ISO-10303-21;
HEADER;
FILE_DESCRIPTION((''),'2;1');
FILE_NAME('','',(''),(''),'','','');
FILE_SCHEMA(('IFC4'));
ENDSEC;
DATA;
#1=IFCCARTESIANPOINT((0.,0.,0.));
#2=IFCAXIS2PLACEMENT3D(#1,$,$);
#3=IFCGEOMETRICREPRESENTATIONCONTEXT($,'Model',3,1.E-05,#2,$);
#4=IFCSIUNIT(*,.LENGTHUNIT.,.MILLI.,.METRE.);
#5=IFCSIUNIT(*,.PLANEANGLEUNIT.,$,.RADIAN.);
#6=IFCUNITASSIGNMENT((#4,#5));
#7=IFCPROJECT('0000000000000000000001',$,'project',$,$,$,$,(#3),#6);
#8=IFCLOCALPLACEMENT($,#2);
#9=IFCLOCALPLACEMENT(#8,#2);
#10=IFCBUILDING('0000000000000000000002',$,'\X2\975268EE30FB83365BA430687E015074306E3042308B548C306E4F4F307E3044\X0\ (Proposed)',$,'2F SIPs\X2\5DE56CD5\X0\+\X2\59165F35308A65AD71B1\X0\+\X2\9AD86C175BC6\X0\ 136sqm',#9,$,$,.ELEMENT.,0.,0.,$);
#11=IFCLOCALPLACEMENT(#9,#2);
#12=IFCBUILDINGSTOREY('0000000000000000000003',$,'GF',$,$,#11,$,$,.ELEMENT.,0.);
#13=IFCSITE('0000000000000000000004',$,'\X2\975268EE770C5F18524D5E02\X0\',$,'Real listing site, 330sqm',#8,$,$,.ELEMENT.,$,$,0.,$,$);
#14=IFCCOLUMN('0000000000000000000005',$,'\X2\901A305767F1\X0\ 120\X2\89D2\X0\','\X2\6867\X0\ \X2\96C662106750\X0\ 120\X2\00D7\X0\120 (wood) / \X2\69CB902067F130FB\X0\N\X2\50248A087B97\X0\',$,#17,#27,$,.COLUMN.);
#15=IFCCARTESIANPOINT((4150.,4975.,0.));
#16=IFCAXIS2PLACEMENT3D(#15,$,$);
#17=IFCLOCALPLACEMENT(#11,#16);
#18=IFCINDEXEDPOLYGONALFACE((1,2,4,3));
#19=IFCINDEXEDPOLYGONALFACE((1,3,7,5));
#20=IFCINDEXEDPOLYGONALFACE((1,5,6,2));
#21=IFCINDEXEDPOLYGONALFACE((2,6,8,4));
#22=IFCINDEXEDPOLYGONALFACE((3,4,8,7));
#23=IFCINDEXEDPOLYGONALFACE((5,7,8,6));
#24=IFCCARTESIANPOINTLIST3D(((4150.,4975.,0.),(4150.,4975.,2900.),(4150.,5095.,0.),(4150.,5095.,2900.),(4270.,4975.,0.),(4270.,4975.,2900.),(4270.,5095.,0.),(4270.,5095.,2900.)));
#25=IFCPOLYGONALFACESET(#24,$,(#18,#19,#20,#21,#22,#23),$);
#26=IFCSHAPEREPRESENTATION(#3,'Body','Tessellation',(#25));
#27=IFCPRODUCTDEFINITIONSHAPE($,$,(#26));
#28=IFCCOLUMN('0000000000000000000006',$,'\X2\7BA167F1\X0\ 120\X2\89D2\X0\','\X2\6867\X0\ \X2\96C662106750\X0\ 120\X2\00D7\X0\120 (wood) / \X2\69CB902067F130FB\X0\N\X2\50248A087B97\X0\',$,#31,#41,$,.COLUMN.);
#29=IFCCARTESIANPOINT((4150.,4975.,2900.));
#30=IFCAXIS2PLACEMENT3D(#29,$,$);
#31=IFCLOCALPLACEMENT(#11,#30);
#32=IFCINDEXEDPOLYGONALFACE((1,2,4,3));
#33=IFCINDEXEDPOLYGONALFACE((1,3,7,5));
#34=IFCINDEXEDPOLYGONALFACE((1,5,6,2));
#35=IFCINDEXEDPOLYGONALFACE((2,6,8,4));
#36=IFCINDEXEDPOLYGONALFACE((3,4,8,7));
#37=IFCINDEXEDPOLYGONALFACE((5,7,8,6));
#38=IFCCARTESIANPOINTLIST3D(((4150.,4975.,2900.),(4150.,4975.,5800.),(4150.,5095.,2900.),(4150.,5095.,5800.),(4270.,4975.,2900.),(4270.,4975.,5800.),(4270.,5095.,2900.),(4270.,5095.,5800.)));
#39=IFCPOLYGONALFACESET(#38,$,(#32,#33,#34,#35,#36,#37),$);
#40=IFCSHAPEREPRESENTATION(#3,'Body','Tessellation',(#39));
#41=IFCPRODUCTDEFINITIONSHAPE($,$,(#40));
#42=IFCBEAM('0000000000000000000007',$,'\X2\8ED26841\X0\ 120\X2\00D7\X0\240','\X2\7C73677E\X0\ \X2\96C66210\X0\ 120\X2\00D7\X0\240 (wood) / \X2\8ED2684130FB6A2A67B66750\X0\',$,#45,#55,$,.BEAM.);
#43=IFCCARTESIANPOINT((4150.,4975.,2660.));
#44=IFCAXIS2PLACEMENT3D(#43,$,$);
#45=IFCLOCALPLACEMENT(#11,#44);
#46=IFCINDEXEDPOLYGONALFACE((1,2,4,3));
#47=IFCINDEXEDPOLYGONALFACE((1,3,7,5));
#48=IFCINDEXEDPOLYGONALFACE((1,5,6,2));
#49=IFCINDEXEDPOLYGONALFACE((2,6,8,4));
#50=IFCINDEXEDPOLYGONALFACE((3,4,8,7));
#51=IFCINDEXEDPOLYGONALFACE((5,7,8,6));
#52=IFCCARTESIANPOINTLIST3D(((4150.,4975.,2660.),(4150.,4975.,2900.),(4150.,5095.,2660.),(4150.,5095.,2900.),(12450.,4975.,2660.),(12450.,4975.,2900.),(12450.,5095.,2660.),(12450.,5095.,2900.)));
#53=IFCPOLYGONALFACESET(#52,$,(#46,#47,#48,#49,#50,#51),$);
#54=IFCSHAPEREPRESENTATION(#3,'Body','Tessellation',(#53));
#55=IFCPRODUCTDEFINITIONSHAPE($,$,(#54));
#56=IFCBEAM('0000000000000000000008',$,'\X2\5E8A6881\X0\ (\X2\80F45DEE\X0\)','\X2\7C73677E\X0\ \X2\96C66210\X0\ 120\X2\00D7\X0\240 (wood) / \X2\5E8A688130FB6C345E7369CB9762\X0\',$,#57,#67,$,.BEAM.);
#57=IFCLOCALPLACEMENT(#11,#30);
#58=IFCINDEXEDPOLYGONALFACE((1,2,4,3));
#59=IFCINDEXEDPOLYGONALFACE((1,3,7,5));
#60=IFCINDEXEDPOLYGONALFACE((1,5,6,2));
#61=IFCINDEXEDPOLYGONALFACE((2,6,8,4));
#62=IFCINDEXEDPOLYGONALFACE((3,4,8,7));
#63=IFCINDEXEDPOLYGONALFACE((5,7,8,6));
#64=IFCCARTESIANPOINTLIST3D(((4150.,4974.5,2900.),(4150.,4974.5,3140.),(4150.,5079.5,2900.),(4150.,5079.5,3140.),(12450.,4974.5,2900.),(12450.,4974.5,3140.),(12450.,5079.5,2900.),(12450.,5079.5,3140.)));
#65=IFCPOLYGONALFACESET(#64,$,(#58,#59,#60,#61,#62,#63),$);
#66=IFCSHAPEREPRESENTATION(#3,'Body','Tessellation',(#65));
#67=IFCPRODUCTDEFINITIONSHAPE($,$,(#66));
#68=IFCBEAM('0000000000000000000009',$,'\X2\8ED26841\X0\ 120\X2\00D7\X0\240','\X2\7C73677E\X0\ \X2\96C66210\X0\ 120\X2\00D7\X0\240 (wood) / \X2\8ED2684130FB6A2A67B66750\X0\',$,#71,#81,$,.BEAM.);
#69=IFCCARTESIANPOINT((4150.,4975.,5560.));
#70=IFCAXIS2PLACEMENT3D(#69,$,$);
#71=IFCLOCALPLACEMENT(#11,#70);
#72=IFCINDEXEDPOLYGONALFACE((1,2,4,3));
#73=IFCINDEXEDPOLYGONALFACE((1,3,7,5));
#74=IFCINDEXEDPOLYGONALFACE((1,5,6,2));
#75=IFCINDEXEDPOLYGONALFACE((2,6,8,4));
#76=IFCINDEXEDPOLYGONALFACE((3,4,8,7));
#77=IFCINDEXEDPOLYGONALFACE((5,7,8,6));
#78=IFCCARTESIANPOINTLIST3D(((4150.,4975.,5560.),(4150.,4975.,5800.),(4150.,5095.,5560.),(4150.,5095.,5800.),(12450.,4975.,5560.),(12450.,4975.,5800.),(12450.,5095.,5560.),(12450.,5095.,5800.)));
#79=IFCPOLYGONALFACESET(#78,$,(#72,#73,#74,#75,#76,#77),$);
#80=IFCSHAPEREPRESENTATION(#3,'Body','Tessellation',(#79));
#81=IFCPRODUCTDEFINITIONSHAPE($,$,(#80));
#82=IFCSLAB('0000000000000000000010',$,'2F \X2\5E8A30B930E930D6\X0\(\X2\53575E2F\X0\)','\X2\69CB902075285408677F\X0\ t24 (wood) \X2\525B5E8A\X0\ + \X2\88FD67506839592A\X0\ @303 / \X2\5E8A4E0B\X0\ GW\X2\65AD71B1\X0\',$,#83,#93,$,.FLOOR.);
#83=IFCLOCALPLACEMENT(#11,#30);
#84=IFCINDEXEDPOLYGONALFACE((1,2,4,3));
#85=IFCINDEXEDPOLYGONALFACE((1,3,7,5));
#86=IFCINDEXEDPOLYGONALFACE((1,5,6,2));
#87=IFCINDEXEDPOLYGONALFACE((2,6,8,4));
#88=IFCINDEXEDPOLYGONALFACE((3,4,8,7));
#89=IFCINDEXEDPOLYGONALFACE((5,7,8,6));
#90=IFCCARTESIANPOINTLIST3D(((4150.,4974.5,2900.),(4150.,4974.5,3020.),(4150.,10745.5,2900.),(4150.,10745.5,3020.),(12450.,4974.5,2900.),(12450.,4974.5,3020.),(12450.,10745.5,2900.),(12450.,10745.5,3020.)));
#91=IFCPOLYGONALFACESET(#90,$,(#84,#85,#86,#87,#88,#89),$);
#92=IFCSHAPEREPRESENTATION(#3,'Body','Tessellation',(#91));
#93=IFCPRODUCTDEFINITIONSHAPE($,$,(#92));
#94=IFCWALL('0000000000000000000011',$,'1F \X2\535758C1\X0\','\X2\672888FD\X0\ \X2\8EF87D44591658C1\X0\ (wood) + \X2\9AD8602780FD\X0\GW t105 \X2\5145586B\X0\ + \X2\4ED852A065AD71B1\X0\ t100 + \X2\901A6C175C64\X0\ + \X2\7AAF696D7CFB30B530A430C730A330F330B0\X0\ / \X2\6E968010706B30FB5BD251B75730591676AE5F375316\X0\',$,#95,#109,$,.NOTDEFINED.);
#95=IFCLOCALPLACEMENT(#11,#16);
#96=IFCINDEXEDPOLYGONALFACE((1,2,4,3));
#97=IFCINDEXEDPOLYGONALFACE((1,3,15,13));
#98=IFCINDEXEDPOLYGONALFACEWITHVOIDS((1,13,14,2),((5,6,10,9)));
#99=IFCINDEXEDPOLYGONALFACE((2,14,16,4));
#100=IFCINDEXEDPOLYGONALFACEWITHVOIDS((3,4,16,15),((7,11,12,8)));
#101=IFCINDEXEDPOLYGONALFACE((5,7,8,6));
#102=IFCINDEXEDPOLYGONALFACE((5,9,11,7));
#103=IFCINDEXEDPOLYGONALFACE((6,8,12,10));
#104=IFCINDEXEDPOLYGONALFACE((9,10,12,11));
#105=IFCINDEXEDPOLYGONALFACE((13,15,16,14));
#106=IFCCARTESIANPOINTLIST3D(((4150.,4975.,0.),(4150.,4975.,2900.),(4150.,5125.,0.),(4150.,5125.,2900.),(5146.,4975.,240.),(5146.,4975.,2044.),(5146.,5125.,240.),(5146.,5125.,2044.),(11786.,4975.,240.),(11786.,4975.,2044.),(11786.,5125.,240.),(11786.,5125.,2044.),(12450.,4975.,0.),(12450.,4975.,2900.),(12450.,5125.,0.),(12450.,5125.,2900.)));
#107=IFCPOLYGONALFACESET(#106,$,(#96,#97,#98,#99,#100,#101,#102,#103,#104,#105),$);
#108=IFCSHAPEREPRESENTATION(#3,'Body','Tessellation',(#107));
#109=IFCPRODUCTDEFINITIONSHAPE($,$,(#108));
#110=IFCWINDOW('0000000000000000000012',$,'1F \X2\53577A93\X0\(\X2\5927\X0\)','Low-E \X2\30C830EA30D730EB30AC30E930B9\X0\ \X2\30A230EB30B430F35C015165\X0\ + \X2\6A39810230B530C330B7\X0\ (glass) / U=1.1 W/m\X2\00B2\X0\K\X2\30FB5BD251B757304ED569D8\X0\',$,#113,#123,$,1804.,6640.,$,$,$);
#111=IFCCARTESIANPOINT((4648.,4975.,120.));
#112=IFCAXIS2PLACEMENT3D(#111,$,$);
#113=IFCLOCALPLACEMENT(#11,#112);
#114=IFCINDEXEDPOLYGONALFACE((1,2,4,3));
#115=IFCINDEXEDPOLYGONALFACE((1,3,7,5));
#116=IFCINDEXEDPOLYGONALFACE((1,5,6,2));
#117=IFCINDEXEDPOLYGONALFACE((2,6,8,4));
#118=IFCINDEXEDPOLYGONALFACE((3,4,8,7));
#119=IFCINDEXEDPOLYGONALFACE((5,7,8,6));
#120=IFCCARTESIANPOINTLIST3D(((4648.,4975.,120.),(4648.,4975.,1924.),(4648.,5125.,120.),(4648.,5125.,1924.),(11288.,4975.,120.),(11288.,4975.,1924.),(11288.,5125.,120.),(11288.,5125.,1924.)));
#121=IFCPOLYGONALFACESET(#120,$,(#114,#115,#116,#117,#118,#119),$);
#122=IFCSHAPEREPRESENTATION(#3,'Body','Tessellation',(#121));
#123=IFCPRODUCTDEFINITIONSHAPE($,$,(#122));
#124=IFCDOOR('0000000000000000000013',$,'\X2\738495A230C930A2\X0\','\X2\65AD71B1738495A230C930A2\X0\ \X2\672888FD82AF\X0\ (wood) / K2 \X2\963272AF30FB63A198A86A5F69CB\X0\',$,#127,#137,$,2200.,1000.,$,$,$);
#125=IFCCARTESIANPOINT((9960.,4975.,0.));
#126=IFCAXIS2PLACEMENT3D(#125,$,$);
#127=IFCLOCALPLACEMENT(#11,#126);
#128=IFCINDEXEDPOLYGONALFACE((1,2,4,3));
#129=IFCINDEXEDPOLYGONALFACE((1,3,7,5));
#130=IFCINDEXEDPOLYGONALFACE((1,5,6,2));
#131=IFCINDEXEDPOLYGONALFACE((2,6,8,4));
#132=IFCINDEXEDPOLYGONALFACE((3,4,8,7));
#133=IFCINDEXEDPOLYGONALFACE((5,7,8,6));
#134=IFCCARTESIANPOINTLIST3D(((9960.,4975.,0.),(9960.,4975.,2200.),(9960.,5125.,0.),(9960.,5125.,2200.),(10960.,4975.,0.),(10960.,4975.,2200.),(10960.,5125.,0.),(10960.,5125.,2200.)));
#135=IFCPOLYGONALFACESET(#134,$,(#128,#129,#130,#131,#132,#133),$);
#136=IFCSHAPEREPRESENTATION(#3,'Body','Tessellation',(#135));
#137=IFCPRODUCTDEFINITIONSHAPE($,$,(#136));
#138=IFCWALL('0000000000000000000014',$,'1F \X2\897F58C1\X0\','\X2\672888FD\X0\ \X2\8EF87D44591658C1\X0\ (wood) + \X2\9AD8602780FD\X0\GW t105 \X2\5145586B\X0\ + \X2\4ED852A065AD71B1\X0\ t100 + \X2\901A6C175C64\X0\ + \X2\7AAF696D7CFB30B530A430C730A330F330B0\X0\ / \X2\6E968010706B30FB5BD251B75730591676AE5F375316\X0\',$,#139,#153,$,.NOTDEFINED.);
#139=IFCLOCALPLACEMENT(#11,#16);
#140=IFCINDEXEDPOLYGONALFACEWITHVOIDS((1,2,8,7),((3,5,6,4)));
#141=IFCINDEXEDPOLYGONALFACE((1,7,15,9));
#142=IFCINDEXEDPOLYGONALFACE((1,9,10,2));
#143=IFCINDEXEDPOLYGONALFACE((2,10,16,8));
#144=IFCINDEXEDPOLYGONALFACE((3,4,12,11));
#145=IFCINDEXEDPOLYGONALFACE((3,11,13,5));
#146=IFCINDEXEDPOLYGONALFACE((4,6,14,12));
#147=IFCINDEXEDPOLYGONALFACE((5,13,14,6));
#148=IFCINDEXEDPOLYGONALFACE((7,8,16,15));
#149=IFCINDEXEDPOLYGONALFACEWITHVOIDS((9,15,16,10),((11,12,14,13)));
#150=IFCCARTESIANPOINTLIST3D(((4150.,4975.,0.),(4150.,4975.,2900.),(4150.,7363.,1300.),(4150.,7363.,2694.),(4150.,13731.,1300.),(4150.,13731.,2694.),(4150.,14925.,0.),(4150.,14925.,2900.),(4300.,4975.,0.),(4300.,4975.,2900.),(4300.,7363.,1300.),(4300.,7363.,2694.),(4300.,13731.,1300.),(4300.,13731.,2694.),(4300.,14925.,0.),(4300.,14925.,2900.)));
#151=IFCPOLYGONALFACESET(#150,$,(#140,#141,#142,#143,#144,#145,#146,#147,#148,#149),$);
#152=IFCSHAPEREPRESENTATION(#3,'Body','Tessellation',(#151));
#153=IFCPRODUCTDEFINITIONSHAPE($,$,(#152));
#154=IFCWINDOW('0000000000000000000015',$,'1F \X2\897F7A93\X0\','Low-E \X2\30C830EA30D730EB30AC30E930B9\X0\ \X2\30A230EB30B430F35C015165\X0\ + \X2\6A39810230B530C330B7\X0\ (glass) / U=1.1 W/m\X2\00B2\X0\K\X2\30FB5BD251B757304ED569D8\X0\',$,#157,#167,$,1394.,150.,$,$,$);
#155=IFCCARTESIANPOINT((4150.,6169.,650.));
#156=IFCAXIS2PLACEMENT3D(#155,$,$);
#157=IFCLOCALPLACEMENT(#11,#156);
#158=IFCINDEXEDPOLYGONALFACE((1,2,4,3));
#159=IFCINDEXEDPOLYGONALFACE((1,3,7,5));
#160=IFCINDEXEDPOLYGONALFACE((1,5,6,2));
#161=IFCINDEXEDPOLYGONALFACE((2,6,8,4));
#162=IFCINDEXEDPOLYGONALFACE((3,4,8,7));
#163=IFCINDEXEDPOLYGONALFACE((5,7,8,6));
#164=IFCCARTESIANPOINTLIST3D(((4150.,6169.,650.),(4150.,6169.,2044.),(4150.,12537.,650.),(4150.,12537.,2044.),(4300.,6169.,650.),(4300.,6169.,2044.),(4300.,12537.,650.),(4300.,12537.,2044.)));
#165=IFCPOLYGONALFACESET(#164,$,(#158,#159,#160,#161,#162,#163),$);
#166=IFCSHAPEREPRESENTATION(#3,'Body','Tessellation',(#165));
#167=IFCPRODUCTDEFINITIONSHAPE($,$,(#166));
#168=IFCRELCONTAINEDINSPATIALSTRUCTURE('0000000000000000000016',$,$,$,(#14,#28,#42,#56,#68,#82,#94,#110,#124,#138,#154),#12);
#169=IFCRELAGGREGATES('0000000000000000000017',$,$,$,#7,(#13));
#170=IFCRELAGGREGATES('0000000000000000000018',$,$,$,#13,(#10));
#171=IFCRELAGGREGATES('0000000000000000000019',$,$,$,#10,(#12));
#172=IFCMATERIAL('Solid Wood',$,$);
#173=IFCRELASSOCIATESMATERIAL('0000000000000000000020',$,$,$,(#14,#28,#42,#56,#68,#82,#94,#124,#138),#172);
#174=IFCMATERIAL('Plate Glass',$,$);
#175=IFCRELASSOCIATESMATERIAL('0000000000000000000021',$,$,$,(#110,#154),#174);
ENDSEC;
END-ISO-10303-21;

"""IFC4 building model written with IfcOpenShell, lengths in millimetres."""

from ifc_helpers import new_model, si_unit, frame, frame_2d, origin, place, context, project, spatial, rectangle, extrude, material, element, fill, save


model = new_model("IFC4")

# Units and contexts
model_context = context("Model", 3, precision=1e-05, world=origin())
ifc_project = project(units=[si_unit("LENGTHUNIT", "METRE", prefix="MILLI"), si_unit("PLANEANGLEUNIT", "RADIAN")], contexts=[model_context])

# Site, building, storey
site_placement = place(None, origin())
site = spatial("IfcSite", under=ifc_project, at=site_placement, Name="青森県弘前市", ObjectType="Real listing site, 330sqm", CompositionType="ELEMENT", RefElevation=0.0)
building_placement = place(site_placement, origin())
building = spatial("IfcBuilding", under=site, at=building_placement, Name="青森・茶室と縁側のある和の住まい (Proposed)", ObjectType="2F SIPs工法+外張り断熱+高気密 136sqm", CompositionType="ELEMENT", ElevationOfRefHeight=0.0, ElevationOfTerrain=0.0)
storey_placement = place(building_placement, origin())
storey = spatial("IfcBuildingStorey", under=building, at=storey_placement, Name="GF", CompositionType="ELEMENT", Elevation=0.0)

# Columns
ifc_material_1 = material(Name="Solid Wood")
column_1_placement = place(storey_placement, frame((4150.0, 4975.0, 0.0)))
element("IfcColumn", 1, at=column_1_placement, inside=storey, material=ifc_material_1, Name="通し柱 120角", Description="桧 集成材 120×120 (wood) / 構造柱・N値計算", PredefinedType="COLUMN", context=model_context, shape_type="SweptSolid", body=[
    extrude(rectangle(XDim=120.0, YDim=120.0, at=frame_2d((60.0, 60.0))), frame((4150.0, 4975.0, 0.0)), (0.0, 0.0, 1.0), 2900.0),
])
column_2_placement = place(storey_placement, frame((4150.0, 4975.0, 2900.0)))
element("IfcColumn", 2, at=column_2_placement, inside=storey, material=ifc_material_1, Name="管柱 120角", Description="桧 集成材 120×120 (wood) / 構造柱・N値計算", PredefinedType="COLUMN", context=model_context, shape_type="SweptSolid", body=[
    extrude(rectangle(XDim=120.0, YDim=120.0, at=frame_2d((60.0, 60.0))), frame((4150.0, 4975.0, 2900.0)), (0.0, 0.0, 1.0), 2900.0),
])

# Beams
beam_1_placement = place(storey_placement, frame((4150.0, 4975.0, 2660.0)))
element("IfcBeam", 3, at=beam_1_placement, inside=storey, material=ifc_material_1, Name="軒桁 120×240", Description="米松 集成 120×240 (wood) / 軒桁・横架材", PredefinedType="BEAM", context=model_context, shape_type="SweptSolid", body=[
    extrude(rectangle(XDim=8300.0, YDim=120.0, at=frame_2d((4150.0, 60.0))), frame((4150.0, 4975.0, 2660.0)), (0.0, 0.0, 1.0), 240.0),
])
beam_2_placement = place(storey_placement, frame((4150.0, 4975.0, 2900.0)))
element("IfcBeam", 4, at=beam_2_placement, inside=storey, material=ifc_material_1, Name="床梁 (胴差)", Description="米松 集成 120×240 (wood) / 床梁・水平構面", PredefinedType="BEAM", context=model_context, shape_type="SweptSolid", body=[
    extrude(rectangle(XDim=8300.0, YDim=105.0, at=frame_2d((4150.0, 52.0))), frame((4150.0, 4975.0, 2900.0)), (0.0, 0.0, 1.0), 240.0),
])
beam_3_placement = place(storey_placement, frame((4150.0, 4975.0, 5560.0)))
element("IfcBeam", 5, at=beam_3_placement, inside=storey, material=ifc_material_1, Name="軒桁 120×240", Description="米松 集成 120×240 (wood) / 軒桁・横架材", PredefinedType="BEAM", context=model_context, shape_type="SweptSolid", body=[
    extrude(rectangle(XDim=8300.0, YDim=120.0, at=frame_2d((4150.0, 60.0))), frame((4150.0, 4975.0, 5560.0)), (0.0, 0.0, 1.0), 240.0),
])

# Slab
slab_1_placement = place(storey_placement, frame((4150.0, 4975.0, 2900.0)))
element("IfcSlab", 6, at=slab_1_placement, inside=storey, material=ifc_material_1, Name="2F 床スラブ(南帯)", Description="構造用合板 t24 (wood) 剛床 + 製材根太 @303 / 床下 GW断熱", PredefinedType="FLOOR", context=model_context, shape_type="SweptSolid", body=[
    extrude(rectangle(XDim=8300.0, YDim=5771.0, at=frame_2d((4150.0, 2885.0))), frame((4150.0, 4975.0, 2900.0)), (0.0, 0.0, 1.0), 120.0),
])

# Wall, openings, window, door
wall_1_placement = place(storey_placement, frame((4150.0, 4975.0, 0.0)))
wall_1 = element("IfcWall", 7, at=wall_1_placement, inside=storey, material=ifc_material_1, Name="1F 南壁", Description="木製 軸組外壁 (wood) + 高性能GW t105 充填 + 付加断熱 t100 + 通気層 + 窯業系サイディング / 準耐火・寒冷地外皮強化", PredefinedType="NOTDEFINED", context=model_context, shape_type="SweptSolid", body=[
    extrude(rectangle(XDim=8300.0, YDim=150.0, at=frame_2d((4150.0, 75.0))), frame((4150.0, 4975.0, 0.0)), (0.0, 0.0, 1.0), 2900.0),
])
opening_1_placement = place(storey_placement, frame((4648.0, 4975.0, 120.0)))
opening_1 = element("IfcOpeningElement", 8, at=opening_1_placement, cuts=wall_1, PredefinedType="NOTDEFINED", context=model_context, shape_type="SweptSolid", body=[
    extrude(rectangle(XDim=6640.0, YDim=150.0, at=frame_2d((3320.0, 75.0))), frame((4648.0, 4975.0, 120.0)), (0.0, 0.0, 1.0), 1804.0),
])
opening_2_placement = place(storey_placement, frame((9960.0, 4975.0, 0.0)))
opening_2 = element("IfcOpeningElement", 9, at=opening_2_placement, cuts=wall_1, PredefinedType="NOTDEFINED", context=model_context, shape_type="SweptSolid", body=[
    extrude(rectangle(XDim=1000.0, YDim=150.0, at=frame_2d((500.0, 75.0))), frame((9960.0, 4975.0, 0.0)), (0.0, 0.0, 1.0), 2200.0),
])
ifc_material_2 = material(Name="Plate Glass")
window_1_placement = place(storey_placement, frame((4648.0, 4975.0, 120.0)))
window_1 = element("IfcWindow", 10, at=window_1_placement, inside=storey, material=ifc_material_2, Name="1F 南窓(大)", Description="Low-E トリプルガラス アルゴン封入 + 樹脂サッシ (glass) / U=1.1 W/m²K・寒冷地仕様", OverallHeight=1804.0, OverallWidth=6640.0, context=model_context, shape_type="SweptSolid", body=[
    extrude(rectangle(XDim=6640.0, YDim=150.0, at=frame_2d((3320.0, 75.0))), frame((4648.0, 4975.0, 120.0)), (0.0, 0.0, 1.0), 1804.0),
])
fill(opening_1, window_1)
door_placement = place(storey_placement, frame((9960.0, 4975.0, 0.0)))
door = element("IfcDoor", 11, at=door_placement, inside=storey, material=ifc_material_1, Name="玄関ドア", Description="断熱玄関ドア 木製芯 (wood) / K2 防犯・採風機構", OverallHeight=2200.0, OverallWidth=1000.0, context=model_context, shape_type="SweptSolid", body=[
    extrude(rectangle(XDim=1000.0, YDim=150.0, at=frame_2d((500.0, 75.0))), frame((9960.0, 4975.0, 0.0)), (0.0, 0.0, 1.0), 2200.0),
])
fill(opening_2, door)

# Wall, opening, window
wall_2_placement = place(storey_placement, frame((4150.0, 4975.0, 0.0)))
wall_2 = element("IfcWall", 12, at=wall_2_placement, inside=storey, material=ifc_material_1, Name="1F 西壁", Description="木製 軸組外壁 (wood) + 高性能GW t105 充填 + 付加断熱 t100 + 通気層 + 窯業系サイディング / 準耐火・寒冷地外皮強化", PredefinedType="NOTDEFINED", context=model_context, shape_type="SweptSolid", body=[
    extrude(rectangle(XDim=150.0, YDim=9950.0, at=frame_2d((75.0, 4975.0))), frame((4150.0, 4975.0, 0.0)), (0.0, 0.0, 1.0), 2900.0),
])
opening_3_placement = place(storey_placement, frame((4150.0, 6169.0, 650.0)))
opening_3 = element("IfcOpeningElement", 13, at=opening_3_placement, cuts=wall_2, PredefinedType="NOTDEFINED", context=model_context, shape_type="SweptSolid", body=[
    extrude(rectangle(XDim=150.0, YDim=6368.0, at=frame_2d((75.0, 3184.0))), frame((4150.0, 6169.0, 650.0)), (0.0, 0.0, 1.0), 1394.0),
])
window_2_placement = place(storey_placement, frame((4150.0, 6169.0, 650.0)))
window_2 = element("IfcWindow", 14, at=window_2_placement, inside=storey, material=ifc_material_2, Name="1F 西窓", Description="Low-E トリプルガラス アルゴン封入 + 樹脂サッシ (glass) / U=1.1 W/m²K・寒冷地仕様", OverallHeight=1394.0, OverallWidth=150.0, context=model_context, shape_type="SweptSolid", body=[
    extrude(rectangle(XDim=150.0, YDim=6368.0, at=frame_2d((75.0, 3184.0))), frame((4150.0, 6169.0, 650.0)), (0.0, 0.0, 1.0), 1394.0),
])
fill(opening_3, window_2)

save(model, "model.ifc")
